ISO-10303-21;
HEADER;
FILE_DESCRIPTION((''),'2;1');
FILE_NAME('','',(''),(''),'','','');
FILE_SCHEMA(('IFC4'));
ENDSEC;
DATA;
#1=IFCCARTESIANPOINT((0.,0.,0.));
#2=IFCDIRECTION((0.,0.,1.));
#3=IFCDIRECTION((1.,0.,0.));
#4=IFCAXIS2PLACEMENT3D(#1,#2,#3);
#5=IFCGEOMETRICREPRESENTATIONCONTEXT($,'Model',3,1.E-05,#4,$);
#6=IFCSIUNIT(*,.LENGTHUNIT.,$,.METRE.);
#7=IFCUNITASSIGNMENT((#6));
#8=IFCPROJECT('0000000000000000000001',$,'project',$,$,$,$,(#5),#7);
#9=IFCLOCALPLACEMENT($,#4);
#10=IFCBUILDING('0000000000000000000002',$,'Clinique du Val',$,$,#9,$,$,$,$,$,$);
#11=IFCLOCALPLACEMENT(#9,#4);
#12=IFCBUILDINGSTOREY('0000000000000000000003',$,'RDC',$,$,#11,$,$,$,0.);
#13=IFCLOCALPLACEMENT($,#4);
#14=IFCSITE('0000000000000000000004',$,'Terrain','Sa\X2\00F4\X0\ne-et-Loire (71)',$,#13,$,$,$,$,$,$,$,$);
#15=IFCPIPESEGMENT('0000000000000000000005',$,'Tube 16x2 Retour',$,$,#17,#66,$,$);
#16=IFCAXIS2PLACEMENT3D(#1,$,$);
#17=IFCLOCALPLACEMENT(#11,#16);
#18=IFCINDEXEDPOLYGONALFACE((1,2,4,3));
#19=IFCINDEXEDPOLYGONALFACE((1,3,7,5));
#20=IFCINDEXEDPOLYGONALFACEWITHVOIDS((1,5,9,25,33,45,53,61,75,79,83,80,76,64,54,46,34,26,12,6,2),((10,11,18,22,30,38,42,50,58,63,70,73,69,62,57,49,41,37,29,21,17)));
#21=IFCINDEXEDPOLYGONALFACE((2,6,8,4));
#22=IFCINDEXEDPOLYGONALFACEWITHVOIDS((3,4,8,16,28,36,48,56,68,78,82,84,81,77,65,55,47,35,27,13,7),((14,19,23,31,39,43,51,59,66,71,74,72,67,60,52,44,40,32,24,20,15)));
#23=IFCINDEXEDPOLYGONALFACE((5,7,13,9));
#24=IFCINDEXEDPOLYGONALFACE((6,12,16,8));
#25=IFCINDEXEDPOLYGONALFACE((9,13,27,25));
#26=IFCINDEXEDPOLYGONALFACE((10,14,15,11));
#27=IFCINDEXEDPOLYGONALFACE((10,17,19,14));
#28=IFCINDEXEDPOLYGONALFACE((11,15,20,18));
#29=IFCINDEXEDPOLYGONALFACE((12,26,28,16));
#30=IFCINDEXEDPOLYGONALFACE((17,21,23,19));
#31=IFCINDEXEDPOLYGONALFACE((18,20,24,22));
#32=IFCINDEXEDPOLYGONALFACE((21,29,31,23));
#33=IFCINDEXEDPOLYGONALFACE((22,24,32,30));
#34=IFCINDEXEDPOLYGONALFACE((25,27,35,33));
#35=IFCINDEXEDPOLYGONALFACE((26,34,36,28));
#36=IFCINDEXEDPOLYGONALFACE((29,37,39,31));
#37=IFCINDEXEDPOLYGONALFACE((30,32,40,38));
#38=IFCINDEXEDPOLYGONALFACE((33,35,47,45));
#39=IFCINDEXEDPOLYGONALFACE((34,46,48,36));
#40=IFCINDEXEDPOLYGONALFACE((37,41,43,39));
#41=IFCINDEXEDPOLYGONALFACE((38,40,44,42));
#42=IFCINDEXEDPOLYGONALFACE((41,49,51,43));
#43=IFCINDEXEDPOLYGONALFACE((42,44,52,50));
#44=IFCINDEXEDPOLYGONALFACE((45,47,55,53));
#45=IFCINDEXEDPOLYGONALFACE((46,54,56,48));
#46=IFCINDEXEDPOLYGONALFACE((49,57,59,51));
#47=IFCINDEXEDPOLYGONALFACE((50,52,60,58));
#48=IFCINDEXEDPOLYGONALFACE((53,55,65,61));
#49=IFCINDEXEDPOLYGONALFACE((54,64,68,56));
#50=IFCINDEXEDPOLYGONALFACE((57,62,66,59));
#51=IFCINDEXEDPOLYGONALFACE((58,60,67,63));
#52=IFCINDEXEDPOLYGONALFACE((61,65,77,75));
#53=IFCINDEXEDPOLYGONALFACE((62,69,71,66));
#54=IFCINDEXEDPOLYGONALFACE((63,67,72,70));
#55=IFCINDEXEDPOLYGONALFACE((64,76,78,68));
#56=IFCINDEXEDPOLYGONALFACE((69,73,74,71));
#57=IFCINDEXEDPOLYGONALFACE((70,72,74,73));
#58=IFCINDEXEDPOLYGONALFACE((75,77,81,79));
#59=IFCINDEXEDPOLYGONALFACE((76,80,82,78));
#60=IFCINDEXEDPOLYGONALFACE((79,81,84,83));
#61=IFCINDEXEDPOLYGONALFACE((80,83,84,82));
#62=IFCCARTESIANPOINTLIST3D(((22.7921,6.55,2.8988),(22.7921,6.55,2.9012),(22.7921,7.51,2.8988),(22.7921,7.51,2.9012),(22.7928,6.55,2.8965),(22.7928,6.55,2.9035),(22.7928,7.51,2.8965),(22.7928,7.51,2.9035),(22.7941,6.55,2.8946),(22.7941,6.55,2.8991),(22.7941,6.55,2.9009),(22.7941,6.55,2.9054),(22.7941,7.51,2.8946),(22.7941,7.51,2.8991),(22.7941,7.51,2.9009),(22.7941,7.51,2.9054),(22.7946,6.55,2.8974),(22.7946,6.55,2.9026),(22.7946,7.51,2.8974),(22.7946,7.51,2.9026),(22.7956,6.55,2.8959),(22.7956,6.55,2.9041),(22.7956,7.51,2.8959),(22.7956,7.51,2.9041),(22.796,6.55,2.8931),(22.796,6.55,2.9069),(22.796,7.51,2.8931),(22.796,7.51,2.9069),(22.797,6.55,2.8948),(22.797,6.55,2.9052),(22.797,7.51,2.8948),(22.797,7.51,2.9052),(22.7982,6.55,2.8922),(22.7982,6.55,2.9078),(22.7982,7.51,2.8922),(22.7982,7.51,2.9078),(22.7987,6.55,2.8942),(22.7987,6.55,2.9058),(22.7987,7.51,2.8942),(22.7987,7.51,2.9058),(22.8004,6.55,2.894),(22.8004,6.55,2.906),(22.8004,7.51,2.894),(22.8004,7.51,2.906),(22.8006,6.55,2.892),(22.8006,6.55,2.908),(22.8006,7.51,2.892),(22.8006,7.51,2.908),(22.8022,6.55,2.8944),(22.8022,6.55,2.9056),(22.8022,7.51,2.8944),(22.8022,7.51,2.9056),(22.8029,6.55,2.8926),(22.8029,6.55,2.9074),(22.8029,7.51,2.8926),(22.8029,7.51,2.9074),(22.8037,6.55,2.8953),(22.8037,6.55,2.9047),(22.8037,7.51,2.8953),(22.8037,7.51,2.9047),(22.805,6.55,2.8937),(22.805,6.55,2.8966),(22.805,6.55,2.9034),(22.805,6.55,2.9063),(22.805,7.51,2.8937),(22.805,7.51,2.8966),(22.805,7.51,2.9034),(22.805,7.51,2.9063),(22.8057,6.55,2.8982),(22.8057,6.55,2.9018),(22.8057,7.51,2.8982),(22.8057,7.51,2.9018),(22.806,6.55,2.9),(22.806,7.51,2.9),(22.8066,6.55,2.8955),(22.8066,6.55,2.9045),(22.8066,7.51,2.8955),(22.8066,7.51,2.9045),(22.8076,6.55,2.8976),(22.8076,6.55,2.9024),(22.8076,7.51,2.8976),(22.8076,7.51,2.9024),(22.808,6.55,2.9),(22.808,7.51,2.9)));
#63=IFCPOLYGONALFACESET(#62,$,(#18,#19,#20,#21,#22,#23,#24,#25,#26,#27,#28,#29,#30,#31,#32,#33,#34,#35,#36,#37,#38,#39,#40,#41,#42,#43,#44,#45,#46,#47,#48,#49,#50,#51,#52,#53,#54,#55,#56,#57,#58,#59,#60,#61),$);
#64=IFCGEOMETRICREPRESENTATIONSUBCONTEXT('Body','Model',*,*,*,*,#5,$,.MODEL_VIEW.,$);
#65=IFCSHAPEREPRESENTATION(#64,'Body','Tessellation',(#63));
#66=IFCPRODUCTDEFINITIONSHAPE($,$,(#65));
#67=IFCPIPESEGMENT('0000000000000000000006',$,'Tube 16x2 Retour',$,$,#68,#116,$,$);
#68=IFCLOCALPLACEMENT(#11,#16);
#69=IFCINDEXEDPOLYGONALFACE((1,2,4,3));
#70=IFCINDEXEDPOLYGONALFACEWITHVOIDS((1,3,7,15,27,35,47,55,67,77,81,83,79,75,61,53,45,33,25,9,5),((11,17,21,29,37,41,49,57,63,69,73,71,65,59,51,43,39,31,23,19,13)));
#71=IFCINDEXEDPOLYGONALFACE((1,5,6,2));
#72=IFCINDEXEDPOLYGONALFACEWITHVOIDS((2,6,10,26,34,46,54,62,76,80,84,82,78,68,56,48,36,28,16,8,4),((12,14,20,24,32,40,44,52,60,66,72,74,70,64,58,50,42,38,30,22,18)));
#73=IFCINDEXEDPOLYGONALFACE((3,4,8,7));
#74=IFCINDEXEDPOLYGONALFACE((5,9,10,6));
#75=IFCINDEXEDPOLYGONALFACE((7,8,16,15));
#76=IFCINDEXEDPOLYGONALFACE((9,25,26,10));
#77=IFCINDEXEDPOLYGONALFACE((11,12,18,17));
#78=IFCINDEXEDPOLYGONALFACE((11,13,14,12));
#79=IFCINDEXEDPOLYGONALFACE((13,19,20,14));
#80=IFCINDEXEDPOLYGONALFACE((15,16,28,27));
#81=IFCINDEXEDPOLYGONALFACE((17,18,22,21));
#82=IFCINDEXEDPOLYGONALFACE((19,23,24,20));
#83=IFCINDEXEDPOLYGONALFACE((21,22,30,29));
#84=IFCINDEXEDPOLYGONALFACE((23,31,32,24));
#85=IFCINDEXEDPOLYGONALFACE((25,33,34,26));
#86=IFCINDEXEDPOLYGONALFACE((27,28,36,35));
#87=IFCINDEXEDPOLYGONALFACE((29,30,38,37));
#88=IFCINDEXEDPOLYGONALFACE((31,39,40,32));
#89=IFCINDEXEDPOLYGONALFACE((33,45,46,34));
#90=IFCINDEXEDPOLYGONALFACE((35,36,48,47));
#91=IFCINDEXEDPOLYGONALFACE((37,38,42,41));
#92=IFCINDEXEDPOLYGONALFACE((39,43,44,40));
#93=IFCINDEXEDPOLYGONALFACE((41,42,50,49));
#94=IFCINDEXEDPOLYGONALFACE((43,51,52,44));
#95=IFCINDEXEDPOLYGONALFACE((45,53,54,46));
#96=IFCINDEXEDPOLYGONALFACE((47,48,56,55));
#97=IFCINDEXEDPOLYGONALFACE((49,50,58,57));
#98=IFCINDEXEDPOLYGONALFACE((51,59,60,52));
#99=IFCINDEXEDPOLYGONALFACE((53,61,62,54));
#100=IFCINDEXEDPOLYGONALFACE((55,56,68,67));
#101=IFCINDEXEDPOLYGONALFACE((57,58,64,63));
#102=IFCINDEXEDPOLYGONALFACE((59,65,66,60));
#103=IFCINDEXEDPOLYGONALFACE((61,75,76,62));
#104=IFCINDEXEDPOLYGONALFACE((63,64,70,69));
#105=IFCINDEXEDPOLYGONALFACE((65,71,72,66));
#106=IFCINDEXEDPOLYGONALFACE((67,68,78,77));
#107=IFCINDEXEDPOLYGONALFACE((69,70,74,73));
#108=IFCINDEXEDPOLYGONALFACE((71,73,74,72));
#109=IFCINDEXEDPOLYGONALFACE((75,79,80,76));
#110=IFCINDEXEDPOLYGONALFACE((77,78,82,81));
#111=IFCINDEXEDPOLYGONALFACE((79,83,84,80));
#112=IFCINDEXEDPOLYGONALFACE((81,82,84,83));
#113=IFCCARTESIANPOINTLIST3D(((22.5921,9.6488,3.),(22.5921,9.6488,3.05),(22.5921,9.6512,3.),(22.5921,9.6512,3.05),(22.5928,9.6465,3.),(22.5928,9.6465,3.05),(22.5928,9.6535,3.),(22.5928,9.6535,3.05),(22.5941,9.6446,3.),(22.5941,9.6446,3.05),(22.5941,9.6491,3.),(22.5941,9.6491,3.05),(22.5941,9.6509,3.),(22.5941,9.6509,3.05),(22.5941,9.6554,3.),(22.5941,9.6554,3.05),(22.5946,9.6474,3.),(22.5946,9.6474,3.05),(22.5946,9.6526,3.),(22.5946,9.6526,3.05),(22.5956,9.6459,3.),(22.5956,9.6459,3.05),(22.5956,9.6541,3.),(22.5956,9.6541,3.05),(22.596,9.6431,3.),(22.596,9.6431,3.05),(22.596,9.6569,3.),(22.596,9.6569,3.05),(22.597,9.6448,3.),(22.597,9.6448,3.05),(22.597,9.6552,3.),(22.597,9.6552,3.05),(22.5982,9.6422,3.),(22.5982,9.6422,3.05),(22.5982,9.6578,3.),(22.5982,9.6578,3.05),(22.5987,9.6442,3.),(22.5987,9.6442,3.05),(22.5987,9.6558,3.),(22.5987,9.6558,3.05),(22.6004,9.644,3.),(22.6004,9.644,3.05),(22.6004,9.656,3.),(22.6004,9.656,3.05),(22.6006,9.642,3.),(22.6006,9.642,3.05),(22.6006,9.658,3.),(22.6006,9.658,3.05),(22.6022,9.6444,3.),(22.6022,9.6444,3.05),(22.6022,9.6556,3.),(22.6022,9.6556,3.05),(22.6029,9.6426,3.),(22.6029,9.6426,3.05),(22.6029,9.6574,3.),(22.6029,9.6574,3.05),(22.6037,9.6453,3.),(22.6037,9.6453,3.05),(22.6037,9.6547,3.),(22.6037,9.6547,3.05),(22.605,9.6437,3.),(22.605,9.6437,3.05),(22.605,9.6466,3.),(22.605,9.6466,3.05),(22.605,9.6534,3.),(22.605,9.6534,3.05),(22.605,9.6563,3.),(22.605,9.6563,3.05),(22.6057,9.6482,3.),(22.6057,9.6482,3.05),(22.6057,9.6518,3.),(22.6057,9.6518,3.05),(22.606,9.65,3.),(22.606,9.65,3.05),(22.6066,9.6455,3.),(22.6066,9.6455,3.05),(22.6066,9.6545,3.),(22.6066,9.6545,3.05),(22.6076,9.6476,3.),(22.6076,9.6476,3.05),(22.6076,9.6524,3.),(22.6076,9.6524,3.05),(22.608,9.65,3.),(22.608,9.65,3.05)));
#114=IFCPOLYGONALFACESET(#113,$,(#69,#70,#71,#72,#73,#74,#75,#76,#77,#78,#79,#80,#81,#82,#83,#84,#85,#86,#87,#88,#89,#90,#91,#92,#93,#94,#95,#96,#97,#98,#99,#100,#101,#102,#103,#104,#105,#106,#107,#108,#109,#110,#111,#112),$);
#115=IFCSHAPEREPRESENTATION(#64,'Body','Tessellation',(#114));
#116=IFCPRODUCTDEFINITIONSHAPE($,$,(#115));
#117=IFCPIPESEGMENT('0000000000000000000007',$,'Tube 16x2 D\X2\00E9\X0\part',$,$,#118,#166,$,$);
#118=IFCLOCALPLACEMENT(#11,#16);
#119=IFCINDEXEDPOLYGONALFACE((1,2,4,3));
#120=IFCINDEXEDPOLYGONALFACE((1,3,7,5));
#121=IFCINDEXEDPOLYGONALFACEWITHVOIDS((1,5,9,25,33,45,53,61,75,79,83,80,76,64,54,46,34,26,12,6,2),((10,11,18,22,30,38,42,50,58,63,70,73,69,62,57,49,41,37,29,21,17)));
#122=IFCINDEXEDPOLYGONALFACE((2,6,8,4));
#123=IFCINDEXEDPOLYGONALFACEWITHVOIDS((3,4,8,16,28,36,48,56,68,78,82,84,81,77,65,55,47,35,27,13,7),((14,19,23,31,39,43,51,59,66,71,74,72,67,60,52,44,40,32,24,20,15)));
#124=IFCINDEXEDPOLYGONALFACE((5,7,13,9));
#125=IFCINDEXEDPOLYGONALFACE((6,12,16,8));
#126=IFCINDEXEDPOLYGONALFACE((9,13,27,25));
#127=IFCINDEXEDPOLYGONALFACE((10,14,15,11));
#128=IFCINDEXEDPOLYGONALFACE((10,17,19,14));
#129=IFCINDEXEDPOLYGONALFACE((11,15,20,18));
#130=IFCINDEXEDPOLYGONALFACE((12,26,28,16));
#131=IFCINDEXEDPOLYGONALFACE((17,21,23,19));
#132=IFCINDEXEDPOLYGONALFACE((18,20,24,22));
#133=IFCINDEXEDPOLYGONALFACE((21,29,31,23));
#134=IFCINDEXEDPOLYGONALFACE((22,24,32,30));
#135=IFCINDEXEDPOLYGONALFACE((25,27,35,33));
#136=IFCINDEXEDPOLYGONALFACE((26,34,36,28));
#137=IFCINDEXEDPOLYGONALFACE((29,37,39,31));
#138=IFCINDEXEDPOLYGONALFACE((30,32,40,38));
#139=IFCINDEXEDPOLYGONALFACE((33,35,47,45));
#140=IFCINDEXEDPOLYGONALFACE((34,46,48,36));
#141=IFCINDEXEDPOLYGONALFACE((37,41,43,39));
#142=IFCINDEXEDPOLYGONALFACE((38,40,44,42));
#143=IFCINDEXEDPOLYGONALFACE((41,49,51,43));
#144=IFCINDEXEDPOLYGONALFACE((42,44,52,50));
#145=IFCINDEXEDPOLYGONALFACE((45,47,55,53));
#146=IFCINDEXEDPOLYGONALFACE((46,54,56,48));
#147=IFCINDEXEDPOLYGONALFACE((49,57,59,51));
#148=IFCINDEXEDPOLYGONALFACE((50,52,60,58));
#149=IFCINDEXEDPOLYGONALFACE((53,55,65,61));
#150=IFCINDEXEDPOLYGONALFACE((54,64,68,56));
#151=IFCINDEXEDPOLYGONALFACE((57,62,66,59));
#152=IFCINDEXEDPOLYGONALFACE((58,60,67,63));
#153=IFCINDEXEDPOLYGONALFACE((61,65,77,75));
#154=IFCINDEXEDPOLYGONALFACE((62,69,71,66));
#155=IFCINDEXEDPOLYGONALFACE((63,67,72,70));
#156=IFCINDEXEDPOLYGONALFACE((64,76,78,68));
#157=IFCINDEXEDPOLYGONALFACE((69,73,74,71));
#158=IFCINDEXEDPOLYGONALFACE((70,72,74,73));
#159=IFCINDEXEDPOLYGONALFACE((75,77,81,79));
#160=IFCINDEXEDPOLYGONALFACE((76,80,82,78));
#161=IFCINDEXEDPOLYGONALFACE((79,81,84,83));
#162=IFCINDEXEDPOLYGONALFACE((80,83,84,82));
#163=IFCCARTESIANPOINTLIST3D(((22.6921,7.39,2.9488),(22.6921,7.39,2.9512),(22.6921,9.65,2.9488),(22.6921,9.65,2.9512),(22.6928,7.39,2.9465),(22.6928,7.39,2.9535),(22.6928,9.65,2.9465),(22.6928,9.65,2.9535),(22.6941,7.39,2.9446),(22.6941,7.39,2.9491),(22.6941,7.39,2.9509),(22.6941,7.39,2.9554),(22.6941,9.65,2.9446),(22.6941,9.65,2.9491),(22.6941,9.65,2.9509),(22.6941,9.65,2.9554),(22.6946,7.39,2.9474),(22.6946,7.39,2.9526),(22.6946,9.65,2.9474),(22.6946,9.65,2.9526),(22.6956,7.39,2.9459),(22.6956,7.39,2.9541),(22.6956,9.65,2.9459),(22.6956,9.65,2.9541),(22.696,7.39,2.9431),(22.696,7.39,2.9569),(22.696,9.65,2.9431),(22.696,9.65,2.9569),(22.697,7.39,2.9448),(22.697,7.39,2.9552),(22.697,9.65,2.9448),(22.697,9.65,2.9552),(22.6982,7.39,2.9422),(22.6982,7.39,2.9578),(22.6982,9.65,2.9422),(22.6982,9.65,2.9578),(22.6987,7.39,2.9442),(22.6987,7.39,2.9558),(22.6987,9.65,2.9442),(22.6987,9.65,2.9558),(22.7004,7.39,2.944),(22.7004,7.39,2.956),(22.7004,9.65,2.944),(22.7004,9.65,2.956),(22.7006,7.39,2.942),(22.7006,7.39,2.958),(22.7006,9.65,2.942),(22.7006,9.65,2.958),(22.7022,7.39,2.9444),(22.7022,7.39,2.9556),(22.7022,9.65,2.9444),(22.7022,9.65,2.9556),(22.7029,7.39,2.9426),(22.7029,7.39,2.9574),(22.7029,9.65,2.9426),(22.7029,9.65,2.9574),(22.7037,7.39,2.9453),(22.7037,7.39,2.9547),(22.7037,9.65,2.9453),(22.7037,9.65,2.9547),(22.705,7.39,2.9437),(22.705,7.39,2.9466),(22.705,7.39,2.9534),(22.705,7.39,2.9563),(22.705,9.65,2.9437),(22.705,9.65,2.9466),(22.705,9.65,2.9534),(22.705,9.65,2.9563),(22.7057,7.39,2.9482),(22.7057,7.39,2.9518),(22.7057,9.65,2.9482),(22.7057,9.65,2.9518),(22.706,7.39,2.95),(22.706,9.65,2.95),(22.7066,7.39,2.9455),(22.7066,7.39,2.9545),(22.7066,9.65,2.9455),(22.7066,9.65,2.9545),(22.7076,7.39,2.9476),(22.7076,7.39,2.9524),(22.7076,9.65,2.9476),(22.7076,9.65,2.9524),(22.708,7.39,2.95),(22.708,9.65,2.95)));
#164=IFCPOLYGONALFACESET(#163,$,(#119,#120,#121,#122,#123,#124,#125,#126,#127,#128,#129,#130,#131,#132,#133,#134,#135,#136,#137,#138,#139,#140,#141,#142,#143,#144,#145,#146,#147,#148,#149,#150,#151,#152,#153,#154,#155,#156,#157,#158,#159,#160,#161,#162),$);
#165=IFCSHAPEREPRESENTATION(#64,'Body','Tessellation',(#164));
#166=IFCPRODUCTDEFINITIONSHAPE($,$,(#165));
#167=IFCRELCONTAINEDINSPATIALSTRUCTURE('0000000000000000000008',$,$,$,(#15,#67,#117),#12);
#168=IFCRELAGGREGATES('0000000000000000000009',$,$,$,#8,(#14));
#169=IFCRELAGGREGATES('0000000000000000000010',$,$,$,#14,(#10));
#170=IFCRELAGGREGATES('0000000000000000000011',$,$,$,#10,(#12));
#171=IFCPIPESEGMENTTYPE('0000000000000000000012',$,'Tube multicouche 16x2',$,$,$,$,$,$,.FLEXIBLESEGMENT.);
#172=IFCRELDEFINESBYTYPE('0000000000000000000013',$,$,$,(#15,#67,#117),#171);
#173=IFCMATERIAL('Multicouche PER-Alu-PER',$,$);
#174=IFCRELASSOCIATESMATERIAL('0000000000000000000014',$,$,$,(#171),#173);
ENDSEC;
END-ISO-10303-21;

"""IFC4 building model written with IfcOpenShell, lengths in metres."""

from ifc_helpers import new_model, si_unit, frame, origin_with_axes, place, context, subcontext, project, spatial, hollow_circle, extrude, material, type_object, element, save


model = new_model("IFC4")

# Units and contexts
model_context = context("Model", 3, precision=1e-05, world=origin_with_axes())
body_context = subcontext(model_context, "Body", "Model", "MODEL_VIEW")
ifc_project = project(units=[si_unit("LENGTHUNIT", "METRE")], contexts=[model_context])

# Site, building, storey
site_placement = place(None, origin_with_axes())
site = spatial("IfcSite", under=ifc_project, at=site_placement, Name="Terrain", Description="Saône-et-Loire (71)")
building_placement = place(None, origin_with_axes())
building = spatial("IfcBuilding", under=site, at=building_placement, Name="Clinique du Val")
storey_placement = place(building_placement, origin_with_axes())
storey = spatial("IfcBuildingStorey", under=building, at=storey_placement, Name="RDC", Elevation=0.0)

# Pipe segments
ifc_material_1 = material(Name="Multicouche PER-Alu-PER")
pipe_segment_type = type_object("IfcPipeSegmentType", Name="Tube multicouche 16x2", PredefinedType="FLEXIBLESEGMENT", material=ifc_material_1)
pipe_segment_1_placement = place(storey_placement, frame((22.8, 7.51, 2.9), z_axis=(0.0, -1.0, 0.0), x_axis=(1.0, 0.0, 0.0)))
element("IfcPipeSegment", 1, at=pipe_segment_1_placement, inside=storey, type_object=pipe_segment_type, Name="Tube 16x2 Retour", context=body_context, shape_type="SweptSolid", body=[
    extrude(hollow_circle(Radius=0.008, WallThickness=0.002), origin_with_axes(), (0.0, 0.0, 1.0), 0.96),
])
pipe_segment_2_placement = place(storey_placement, frame((22.6, 9.65, 3.0), z_axis=(0.0, 0.0, 1.0), x_axis=(1.0, 0.0, 0.0)))
element("IfcPipeSegment", 2, at=pipe_segment_2_placement, inside=storey, type_object=pipe_segment_type, Name="Tube 16x2 Retour", context=body_context, shape_type="SweptSolid", body=[
    extrude(hollow_circle(Radius=0.008, WallThickness=0.002), origin_with_axes(), (0.0, 0.0, 1.0), 0.05),
])
pipe_segment_3_placement = place(storey_placement, frame((22.7, 7.39, 2.95), z_axis=(0.0, 1.0, 0.0), x_axis=(1.0, 0.0, 0.0)))
element("IfcPipeSegment", 3, at=pipe_segment_3_placement, inside=storey, type_object=pipe_segment_type, Name="Tube 16x2 Départ", context=body_context, shape_type="SweptSolid", body=[
    extrude(hollow_circle(Radius=0.008, WallThickness=0.002), origin_with_axes(), (0.0, 0.0, 1.0), 2.26),
])

save(model, "model.ifc")
